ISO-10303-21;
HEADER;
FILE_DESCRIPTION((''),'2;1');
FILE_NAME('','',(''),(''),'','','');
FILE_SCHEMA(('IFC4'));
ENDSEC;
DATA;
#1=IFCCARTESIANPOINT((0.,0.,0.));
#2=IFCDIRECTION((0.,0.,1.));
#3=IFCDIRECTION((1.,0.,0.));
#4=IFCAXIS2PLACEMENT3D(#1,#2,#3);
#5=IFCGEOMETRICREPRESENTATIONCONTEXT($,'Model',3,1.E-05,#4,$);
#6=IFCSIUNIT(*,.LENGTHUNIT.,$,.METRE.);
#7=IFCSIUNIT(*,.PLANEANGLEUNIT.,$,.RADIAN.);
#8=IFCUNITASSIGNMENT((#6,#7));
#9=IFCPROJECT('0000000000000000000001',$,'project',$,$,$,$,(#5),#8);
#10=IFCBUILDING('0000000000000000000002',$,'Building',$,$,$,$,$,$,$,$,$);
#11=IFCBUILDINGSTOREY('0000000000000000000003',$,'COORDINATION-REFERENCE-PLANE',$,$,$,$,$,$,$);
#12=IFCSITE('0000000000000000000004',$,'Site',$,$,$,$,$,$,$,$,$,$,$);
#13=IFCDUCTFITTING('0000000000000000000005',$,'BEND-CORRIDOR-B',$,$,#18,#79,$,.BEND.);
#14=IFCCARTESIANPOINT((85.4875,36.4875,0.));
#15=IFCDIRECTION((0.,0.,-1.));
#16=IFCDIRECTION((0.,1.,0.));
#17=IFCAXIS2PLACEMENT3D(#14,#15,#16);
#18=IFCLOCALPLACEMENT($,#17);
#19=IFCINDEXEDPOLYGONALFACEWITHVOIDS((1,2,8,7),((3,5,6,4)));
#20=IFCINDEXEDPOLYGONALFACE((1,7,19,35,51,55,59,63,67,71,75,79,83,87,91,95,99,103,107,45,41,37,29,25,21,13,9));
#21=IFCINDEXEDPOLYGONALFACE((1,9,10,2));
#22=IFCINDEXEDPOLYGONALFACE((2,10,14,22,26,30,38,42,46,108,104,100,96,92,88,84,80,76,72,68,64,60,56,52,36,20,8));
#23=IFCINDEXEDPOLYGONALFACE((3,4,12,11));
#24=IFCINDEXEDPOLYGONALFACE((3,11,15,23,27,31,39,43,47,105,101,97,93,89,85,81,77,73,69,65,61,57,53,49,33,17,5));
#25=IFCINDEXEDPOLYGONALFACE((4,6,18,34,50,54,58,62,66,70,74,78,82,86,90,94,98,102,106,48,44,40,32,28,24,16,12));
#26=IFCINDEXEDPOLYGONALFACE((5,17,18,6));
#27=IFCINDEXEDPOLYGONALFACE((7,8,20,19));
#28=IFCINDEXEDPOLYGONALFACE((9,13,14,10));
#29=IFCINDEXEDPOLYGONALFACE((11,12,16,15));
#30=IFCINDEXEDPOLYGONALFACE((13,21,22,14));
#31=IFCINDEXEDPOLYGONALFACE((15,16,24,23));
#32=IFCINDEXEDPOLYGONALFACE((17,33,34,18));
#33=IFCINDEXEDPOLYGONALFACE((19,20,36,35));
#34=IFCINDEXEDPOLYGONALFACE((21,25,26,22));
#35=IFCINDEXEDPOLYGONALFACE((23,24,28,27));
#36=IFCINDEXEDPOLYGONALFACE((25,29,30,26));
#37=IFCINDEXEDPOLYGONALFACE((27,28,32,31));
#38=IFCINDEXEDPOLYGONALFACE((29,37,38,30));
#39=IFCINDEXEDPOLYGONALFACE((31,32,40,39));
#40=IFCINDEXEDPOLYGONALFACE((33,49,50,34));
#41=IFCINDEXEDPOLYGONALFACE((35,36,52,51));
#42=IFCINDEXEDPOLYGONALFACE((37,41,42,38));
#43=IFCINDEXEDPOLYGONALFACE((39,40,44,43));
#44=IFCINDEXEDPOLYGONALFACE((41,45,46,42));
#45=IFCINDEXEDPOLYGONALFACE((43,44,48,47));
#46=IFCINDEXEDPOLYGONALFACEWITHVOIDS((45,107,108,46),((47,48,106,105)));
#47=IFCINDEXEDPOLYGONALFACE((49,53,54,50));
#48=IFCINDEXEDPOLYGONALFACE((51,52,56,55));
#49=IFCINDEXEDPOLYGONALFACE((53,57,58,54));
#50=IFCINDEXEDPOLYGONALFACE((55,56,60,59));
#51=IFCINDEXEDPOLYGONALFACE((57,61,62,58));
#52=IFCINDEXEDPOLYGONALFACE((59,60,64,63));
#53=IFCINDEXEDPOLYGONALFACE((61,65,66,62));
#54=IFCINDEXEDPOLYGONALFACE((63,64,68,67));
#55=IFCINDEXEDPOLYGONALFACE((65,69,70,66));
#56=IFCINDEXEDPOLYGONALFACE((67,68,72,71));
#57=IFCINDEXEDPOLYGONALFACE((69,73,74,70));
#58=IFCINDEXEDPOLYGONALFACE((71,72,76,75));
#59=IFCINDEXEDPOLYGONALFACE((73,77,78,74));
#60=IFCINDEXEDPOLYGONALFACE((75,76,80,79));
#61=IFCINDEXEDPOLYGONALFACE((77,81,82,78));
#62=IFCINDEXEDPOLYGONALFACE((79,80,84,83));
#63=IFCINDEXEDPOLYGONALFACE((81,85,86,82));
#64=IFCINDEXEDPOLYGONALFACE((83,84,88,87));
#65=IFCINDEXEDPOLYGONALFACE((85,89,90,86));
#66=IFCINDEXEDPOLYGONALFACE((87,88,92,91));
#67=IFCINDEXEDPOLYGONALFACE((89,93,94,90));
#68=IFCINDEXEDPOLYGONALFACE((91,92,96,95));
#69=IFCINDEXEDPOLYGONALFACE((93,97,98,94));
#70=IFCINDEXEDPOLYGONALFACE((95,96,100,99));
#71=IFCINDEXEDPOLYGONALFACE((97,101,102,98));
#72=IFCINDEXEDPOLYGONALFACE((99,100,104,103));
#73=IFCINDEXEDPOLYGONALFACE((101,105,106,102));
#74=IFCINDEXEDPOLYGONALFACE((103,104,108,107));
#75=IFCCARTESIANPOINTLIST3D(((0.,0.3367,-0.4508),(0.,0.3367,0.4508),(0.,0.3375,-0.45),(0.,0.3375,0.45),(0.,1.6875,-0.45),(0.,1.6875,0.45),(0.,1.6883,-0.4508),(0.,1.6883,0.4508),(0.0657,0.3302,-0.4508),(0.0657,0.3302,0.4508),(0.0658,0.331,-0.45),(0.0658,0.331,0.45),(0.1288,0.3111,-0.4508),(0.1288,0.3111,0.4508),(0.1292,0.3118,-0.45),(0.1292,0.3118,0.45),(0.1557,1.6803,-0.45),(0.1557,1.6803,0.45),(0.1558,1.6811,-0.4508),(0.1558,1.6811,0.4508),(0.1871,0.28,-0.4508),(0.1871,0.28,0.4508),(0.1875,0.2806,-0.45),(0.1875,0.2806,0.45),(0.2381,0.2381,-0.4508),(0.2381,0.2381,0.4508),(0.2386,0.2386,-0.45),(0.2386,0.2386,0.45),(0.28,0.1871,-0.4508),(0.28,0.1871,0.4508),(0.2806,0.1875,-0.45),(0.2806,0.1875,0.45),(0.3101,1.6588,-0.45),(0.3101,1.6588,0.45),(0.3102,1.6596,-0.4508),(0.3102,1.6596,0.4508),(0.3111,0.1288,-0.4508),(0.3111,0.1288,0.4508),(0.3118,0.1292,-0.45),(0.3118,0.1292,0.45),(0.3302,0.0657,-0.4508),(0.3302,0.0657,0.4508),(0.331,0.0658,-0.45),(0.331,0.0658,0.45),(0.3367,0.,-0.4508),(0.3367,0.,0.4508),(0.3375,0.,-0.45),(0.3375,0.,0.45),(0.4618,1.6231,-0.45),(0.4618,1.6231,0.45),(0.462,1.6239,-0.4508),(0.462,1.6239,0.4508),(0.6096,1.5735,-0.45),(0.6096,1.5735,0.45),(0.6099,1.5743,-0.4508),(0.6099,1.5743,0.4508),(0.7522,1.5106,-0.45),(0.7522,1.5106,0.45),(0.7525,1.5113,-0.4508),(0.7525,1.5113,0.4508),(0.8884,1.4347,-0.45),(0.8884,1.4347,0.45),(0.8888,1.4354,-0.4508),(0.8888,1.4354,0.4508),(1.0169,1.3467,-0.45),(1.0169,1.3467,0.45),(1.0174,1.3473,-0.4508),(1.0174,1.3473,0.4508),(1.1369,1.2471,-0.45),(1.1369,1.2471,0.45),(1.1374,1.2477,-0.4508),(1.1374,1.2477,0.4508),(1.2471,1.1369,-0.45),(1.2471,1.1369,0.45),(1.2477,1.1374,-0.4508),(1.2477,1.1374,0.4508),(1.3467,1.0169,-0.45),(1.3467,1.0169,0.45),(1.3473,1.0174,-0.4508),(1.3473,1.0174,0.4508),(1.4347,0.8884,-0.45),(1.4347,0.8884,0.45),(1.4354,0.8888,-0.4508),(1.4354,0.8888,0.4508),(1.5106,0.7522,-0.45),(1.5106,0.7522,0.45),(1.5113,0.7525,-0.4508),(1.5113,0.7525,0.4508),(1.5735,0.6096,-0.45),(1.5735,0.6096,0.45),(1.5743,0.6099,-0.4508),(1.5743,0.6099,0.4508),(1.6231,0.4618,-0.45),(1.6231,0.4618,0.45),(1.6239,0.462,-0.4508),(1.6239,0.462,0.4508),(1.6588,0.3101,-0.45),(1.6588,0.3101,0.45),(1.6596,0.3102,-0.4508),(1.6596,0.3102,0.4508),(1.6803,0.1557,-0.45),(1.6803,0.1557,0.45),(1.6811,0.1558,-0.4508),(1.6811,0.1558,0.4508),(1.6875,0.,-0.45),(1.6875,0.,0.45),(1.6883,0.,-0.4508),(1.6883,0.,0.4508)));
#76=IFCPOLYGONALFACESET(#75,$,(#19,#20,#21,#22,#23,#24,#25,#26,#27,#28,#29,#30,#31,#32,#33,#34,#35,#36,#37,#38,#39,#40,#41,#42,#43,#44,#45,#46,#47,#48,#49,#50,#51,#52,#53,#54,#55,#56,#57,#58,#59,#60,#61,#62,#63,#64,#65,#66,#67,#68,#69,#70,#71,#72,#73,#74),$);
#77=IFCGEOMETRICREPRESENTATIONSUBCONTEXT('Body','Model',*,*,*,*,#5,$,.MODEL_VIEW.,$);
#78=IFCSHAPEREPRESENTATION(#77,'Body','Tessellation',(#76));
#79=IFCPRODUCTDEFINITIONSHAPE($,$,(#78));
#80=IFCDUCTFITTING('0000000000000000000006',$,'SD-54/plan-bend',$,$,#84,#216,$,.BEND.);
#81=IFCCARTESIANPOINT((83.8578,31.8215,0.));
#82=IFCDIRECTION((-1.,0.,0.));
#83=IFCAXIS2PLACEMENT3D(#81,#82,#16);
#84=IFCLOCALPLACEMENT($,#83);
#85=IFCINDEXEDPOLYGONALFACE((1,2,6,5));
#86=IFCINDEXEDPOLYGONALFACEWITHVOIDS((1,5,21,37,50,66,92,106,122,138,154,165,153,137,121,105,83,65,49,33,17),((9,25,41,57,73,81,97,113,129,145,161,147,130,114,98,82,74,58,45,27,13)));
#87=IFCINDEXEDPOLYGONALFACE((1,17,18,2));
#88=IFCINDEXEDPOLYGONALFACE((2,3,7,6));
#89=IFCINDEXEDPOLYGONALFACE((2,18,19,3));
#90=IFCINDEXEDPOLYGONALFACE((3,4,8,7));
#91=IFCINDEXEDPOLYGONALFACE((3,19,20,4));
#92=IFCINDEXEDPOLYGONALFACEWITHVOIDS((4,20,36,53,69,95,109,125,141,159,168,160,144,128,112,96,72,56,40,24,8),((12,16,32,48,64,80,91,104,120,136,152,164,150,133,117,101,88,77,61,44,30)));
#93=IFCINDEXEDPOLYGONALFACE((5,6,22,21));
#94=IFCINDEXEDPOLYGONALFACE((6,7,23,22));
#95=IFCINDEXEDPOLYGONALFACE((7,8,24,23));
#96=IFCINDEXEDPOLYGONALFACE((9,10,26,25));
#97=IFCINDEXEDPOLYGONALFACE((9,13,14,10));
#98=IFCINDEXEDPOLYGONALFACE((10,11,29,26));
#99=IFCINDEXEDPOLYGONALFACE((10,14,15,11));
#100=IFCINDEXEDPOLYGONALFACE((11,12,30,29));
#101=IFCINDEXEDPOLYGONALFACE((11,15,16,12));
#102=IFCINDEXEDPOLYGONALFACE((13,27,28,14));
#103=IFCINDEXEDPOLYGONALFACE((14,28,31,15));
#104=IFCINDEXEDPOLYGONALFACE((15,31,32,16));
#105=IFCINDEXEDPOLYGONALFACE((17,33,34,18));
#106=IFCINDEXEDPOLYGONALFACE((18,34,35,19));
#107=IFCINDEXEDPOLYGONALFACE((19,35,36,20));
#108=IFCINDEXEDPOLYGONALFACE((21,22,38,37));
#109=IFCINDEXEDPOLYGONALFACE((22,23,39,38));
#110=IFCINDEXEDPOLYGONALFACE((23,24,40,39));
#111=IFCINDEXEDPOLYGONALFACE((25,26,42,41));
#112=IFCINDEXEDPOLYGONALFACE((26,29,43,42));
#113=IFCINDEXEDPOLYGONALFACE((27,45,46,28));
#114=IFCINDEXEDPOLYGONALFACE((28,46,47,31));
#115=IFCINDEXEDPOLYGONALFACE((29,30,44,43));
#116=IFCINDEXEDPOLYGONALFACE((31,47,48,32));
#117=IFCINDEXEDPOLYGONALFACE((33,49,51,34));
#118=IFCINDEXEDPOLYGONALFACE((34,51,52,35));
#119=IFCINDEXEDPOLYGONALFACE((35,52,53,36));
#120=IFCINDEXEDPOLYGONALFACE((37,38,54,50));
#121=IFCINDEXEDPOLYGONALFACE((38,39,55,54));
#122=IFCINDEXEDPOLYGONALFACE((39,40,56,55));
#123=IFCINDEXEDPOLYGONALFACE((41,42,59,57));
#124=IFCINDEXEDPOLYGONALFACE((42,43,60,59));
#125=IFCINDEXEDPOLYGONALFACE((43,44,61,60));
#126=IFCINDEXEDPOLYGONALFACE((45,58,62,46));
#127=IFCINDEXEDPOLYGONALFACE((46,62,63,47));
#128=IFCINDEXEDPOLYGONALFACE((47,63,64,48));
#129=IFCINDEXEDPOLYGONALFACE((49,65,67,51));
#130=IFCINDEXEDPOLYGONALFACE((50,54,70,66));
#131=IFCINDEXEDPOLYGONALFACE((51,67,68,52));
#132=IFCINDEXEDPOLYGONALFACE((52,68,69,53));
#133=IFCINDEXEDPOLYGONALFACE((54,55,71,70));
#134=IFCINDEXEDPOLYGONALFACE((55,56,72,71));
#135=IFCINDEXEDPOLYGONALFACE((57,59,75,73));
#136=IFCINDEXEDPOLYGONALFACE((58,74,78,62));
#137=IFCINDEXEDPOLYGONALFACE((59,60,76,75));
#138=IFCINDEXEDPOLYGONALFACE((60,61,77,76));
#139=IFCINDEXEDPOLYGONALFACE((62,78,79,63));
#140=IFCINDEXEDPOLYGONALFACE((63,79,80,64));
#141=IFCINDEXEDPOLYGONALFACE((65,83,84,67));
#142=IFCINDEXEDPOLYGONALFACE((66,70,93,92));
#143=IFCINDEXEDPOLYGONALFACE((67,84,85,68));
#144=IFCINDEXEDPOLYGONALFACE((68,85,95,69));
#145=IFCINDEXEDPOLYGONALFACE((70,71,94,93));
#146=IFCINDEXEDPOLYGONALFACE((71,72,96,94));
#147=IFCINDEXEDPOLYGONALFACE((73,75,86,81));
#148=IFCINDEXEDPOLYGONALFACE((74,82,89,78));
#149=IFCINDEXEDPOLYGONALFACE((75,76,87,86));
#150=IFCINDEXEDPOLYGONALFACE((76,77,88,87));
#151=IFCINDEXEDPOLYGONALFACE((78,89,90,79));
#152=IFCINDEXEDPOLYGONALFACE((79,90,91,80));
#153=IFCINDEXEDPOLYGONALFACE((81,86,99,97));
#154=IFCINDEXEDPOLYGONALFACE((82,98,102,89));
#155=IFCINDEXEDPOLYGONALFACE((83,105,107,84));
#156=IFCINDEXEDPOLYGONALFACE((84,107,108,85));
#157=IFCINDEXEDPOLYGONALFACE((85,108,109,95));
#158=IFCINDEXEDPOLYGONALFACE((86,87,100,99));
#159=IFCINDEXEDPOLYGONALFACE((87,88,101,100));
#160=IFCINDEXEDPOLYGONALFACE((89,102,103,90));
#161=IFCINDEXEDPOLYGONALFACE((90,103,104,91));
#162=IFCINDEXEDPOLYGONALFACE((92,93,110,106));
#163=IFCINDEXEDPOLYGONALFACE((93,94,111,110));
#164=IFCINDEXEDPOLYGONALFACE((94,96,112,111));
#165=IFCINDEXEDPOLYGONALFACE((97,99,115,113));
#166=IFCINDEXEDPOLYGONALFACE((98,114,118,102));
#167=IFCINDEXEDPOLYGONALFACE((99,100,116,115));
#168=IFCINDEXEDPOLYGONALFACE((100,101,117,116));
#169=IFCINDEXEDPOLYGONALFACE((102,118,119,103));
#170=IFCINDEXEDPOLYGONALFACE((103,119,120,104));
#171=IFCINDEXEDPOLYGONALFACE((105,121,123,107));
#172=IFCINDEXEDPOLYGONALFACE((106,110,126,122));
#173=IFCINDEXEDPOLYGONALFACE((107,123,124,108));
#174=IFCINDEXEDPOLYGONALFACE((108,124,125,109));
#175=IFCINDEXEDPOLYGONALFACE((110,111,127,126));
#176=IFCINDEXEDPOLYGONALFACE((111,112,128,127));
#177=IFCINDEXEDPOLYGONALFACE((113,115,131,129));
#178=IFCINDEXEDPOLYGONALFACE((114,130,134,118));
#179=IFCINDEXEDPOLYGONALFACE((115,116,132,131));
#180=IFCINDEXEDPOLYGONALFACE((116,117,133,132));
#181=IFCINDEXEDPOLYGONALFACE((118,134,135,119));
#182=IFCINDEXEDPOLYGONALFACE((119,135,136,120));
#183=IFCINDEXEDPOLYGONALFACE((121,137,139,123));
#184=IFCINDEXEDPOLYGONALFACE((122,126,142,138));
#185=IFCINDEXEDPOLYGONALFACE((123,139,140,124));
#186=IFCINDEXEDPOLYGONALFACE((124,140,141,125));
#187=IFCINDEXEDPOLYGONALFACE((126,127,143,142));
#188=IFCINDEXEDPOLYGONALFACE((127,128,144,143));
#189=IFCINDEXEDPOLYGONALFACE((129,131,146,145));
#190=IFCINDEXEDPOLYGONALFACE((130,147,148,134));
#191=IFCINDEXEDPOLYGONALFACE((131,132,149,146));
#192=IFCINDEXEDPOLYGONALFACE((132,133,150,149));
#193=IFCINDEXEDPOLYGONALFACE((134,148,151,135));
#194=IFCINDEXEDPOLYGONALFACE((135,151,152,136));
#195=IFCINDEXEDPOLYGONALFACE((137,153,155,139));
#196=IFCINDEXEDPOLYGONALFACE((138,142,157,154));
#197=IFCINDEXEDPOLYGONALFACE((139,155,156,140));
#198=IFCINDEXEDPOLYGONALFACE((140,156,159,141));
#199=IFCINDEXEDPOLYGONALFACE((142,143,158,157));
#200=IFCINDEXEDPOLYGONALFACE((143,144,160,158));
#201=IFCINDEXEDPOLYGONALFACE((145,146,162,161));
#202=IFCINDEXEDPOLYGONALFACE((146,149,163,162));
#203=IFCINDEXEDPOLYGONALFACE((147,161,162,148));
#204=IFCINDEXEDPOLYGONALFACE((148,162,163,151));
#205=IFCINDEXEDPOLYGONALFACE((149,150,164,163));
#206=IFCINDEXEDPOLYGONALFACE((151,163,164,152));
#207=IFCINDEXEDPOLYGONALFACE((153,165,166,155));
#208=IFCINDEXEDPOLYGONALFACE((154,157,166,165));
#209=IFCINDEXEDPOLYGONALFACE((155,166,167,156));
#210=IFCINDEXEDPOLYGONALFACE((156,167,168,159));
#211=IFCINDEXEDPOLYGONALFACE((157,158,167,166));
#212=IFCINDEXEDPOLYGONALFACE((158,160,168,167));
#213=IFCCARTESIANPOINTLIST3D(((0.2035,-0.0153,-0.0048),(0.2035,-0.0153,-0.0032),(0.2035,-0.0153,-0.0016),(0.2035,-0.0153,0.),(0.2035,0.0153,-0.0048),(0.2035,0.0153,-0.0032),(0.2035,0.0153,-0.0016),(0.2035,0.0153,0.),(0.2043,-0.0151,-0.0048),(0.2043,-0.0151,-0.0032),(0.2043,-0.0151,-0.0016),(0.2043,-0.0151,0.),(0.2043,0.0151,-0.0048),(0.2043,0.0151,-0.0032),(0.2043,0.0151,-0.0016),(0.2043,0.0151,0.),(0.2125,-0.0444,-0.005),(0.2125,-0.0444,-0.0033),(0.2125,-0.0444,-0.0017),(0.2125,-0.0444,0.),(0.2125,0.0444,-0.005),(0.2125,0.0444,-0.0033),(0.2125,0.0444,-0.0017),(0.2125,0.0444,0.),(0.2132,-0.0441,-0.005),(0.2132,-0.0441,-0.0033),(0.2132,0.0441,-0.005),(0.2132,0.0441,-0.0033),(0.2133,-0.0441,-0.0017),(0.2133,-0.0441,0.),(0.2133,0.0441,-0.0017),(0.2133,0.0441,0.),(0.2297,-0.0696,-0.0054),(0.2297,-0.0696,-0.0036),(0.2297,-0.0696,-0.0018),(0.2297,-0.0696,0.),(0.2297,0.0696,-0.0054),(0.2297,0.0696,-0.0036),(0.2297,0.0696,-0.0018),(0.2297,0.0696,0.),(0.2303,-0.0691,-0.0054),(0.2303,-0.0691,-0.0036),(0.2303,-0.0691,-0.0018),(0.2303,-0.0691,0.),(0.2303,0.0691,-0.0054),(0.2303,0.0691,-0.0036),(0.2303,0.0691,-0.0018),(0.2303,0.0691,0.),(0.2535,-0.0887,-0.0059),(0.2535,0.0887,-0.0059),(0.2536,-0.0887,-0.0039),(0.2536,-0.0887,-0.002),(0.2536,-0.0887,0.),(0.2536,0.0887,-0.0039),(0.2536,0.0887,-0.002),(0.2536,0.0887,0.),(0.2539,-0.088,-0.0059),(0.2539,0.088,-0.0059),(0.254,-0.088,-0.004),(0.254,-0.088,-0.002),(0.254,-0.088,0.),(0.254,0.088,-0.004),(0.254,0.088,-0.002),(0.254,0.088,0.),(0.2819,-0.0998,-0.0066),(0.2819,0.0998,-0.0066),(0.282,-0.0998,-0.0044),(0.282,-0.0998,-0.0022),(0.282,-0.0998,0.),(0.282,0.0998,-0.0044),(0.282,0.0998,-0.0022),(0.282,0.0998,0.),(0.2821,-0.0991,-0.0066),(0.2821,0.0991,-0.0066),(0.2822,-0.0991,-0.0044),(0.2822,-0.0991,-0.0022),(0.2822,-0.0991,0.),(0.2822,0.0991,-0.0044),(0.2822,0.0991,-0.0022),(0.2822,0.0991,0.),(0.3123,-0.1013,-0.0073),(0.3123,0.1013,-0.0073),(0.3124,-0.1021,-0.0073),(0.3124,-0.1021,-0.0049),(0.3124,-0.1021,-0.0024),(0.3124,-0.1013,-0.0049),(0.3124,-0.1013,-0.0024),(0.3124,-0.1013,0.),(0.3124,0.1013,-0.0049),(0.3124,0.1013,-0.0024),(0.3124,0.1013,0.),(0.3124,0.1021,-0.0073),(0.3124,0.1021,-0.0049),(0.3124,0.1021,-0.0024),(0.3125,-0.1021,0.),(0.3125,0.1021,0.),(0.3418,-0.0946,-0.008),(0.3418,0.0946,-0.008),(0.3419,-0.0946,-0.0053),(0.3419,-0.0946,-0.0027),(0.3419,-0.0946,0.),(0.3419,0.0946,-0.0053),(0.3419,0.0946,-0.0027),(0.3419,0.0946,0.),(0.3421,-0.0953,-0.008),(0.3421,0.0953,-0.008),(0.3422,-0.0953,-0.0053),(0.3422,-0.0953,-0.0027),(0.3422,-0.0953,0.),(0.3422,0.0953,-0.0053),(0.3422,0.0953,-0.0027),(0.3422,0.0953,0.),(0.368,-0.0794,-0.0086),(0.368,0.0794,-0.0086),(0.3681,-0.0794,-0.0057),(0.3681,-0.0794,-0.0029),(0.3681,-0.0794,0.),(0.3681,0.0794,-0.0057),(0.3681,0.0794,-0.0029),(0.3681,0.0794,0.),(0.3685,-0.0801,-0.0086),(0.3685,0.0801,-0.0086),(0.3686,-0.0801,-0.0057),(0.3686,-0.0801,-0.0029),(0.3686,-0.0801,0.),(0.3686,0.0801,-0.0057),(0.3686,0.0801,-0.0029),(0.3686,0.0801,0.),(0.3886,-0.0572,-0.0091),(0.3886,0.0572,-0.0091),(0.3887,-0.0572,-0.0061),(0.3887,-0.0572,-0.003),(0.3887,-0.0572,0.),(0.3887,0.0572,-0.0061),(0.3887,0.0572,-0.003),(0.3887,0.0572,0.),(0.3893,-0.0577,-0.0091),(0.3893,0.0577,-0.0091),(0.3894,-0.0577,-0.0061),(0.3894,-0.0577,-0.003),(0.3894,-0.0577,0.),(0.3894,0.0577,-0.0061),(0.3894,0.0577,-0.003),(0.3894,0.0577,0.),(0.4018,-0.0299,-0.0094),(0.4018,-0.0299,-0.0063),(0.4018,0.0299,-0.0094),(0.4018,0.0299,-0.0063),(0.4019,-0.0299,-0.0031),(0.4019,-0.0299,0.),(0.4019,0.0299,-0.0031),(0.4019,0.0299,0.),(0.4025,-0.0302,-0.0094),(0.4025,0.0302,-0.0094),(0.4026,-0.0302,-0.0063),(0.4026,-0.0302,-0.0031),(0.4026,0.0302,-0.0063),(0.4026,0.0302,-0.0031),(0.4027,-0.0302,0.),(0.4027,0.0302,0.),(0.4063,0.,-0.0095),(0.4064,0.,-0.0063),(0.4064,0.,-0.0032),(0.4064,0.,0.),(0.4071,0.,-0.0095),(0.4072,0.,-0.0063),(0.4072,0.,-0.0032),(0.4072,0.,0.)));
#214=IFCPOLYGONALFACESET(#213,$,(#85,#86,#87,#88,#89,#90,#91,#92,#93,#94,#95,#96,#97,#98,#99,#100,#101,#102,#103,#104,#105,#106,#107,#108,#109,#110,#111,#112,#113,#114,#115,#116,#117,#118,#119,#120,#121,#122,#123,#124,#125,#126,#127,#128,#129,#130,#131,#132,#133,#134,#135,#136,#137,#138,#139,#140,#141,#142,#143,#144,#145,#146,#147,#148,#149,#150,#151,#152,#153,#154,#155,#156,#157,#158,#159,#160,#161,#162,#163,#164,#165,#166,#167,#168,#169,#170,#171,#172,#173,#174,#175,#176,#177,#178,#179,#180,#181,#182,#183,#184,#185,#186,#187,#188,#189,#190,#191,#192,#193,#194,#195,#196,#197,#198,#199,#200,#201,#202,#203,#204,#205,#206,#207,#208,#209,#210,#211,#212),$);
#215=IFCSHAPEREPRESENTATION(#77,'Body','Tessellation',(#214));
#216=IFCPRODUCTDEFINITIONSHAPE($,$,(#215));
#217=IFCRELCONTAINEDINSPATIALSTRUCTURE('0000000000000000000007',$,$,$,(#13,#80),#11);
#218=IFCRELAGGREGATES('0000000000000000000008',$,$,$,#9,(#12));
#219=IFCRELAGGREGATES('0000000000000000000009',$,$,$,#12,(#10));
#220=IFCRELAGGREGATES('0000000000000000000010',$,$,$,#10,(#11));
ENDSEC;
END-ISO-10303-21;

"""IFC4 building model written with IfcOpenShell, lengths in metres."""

from ifc_helpers import new_model, entity, si_unit, frame, origin_with_axes, place, context, subcontext, project, spatial, element, save


model = new_model("IFC4")

# Units and contexts
model_context = context("Model", 3, precision=1e-05, world=origin_with_axes())
body_context_1 = subcontext(model_context, "Body", "Model", "MODEL_VIEW")
ifc_project = project(units=[si_unit("LENGTHUNIT", "METRE"), si_unit("PLANEANGLEUNIT", "RADIAN")], contexts=[model_context])

# Site, building, storey
site = spatial("IfcSite", under=ifc_project, Name="Site")
building = spatial("IfcBuilding", under=site, Name="Building")
storey = spatial("IfcBuildingStorey", under=building, Name="COORDINATION-REFERENCE-PLANE")

# Duct fitting
duct_fitting_1_placement = place(None, frame((85.4875, 36.4875, 0.0), z_axis=(0.0, 0.0, -1.0), x_axis=(0.0, 1.0, 0.0)))
cartesian_point_1 = entity("IfcCartesianPoint", [0.0, 0.0, 0.0])
element("IfcDuctFitting", 1, at=duct_fitting_1_placement, inside=storey, Name="BEND-CORRIDOR-B", PredefinedType="BEND", context=body_context_1, shape_type="SweptSolid", body=[
    entity("IfcRevolvedAreaSolid", entity("IfcRectangleHollowProfileDef", "AREA", None, entity("IfcAxis2Placement2D", entity("IfcCartesianPoint", [1.0125, 0.0])), 1.3516, 0.9016, 0.0008), entity("IfcAxis2Placement3D", cartesian_point_1, entity("IfcDirection", [0.0, -1.0, 0.0]), entity("IfcDirection", [1.0, 0.0, 0.0])), entity("IfcAxis1Placement", cartesian_point_1, entity("IfcDirection", [0.0, 1.0, 0.0])), 1.570796),
])

# Duct fitting
duct_fitting_2_placement = place(None, frame((83.8578, 31.8215, 0.0), z_axis=(-1.0, 0.0, 0.0), x_axis=(0.0, 1.0, 0.0)))
element("IfcDuctFitting", 2, at=duct_fitting_2_placement, inside=storey, Name="SD-54/plan-bend", PredefinedType="BEND", context=body_context_1, shape_type="SweptSolid", body=[
    entity("IfcRevolvedAreaSolid", entity("IfcCircleHollowProfileDef", "AREA", None, entity("IfcAxis2Placement2D", entity("IfcCartesianPoint", [0.3048, 0.0])), 0.1024, 0.0008), entity("IfcAxis2Placement3D", entity("IfcCartesianPoint", [0.0, 0.0, 0.0]), entity("IfcDirection", [0.0, 0.0, 1.0]), entity("IfcDirection", [1.0, 0.0, 0.0])), entity("IfcAxis1Placement", entity("IfcCartesianPoint", [0.0, 0.0, 0.0]), entity("IfcDirection", [0.0, 1.0, 0.0])), 0.023363),
])

save(model, "model.ifc")
